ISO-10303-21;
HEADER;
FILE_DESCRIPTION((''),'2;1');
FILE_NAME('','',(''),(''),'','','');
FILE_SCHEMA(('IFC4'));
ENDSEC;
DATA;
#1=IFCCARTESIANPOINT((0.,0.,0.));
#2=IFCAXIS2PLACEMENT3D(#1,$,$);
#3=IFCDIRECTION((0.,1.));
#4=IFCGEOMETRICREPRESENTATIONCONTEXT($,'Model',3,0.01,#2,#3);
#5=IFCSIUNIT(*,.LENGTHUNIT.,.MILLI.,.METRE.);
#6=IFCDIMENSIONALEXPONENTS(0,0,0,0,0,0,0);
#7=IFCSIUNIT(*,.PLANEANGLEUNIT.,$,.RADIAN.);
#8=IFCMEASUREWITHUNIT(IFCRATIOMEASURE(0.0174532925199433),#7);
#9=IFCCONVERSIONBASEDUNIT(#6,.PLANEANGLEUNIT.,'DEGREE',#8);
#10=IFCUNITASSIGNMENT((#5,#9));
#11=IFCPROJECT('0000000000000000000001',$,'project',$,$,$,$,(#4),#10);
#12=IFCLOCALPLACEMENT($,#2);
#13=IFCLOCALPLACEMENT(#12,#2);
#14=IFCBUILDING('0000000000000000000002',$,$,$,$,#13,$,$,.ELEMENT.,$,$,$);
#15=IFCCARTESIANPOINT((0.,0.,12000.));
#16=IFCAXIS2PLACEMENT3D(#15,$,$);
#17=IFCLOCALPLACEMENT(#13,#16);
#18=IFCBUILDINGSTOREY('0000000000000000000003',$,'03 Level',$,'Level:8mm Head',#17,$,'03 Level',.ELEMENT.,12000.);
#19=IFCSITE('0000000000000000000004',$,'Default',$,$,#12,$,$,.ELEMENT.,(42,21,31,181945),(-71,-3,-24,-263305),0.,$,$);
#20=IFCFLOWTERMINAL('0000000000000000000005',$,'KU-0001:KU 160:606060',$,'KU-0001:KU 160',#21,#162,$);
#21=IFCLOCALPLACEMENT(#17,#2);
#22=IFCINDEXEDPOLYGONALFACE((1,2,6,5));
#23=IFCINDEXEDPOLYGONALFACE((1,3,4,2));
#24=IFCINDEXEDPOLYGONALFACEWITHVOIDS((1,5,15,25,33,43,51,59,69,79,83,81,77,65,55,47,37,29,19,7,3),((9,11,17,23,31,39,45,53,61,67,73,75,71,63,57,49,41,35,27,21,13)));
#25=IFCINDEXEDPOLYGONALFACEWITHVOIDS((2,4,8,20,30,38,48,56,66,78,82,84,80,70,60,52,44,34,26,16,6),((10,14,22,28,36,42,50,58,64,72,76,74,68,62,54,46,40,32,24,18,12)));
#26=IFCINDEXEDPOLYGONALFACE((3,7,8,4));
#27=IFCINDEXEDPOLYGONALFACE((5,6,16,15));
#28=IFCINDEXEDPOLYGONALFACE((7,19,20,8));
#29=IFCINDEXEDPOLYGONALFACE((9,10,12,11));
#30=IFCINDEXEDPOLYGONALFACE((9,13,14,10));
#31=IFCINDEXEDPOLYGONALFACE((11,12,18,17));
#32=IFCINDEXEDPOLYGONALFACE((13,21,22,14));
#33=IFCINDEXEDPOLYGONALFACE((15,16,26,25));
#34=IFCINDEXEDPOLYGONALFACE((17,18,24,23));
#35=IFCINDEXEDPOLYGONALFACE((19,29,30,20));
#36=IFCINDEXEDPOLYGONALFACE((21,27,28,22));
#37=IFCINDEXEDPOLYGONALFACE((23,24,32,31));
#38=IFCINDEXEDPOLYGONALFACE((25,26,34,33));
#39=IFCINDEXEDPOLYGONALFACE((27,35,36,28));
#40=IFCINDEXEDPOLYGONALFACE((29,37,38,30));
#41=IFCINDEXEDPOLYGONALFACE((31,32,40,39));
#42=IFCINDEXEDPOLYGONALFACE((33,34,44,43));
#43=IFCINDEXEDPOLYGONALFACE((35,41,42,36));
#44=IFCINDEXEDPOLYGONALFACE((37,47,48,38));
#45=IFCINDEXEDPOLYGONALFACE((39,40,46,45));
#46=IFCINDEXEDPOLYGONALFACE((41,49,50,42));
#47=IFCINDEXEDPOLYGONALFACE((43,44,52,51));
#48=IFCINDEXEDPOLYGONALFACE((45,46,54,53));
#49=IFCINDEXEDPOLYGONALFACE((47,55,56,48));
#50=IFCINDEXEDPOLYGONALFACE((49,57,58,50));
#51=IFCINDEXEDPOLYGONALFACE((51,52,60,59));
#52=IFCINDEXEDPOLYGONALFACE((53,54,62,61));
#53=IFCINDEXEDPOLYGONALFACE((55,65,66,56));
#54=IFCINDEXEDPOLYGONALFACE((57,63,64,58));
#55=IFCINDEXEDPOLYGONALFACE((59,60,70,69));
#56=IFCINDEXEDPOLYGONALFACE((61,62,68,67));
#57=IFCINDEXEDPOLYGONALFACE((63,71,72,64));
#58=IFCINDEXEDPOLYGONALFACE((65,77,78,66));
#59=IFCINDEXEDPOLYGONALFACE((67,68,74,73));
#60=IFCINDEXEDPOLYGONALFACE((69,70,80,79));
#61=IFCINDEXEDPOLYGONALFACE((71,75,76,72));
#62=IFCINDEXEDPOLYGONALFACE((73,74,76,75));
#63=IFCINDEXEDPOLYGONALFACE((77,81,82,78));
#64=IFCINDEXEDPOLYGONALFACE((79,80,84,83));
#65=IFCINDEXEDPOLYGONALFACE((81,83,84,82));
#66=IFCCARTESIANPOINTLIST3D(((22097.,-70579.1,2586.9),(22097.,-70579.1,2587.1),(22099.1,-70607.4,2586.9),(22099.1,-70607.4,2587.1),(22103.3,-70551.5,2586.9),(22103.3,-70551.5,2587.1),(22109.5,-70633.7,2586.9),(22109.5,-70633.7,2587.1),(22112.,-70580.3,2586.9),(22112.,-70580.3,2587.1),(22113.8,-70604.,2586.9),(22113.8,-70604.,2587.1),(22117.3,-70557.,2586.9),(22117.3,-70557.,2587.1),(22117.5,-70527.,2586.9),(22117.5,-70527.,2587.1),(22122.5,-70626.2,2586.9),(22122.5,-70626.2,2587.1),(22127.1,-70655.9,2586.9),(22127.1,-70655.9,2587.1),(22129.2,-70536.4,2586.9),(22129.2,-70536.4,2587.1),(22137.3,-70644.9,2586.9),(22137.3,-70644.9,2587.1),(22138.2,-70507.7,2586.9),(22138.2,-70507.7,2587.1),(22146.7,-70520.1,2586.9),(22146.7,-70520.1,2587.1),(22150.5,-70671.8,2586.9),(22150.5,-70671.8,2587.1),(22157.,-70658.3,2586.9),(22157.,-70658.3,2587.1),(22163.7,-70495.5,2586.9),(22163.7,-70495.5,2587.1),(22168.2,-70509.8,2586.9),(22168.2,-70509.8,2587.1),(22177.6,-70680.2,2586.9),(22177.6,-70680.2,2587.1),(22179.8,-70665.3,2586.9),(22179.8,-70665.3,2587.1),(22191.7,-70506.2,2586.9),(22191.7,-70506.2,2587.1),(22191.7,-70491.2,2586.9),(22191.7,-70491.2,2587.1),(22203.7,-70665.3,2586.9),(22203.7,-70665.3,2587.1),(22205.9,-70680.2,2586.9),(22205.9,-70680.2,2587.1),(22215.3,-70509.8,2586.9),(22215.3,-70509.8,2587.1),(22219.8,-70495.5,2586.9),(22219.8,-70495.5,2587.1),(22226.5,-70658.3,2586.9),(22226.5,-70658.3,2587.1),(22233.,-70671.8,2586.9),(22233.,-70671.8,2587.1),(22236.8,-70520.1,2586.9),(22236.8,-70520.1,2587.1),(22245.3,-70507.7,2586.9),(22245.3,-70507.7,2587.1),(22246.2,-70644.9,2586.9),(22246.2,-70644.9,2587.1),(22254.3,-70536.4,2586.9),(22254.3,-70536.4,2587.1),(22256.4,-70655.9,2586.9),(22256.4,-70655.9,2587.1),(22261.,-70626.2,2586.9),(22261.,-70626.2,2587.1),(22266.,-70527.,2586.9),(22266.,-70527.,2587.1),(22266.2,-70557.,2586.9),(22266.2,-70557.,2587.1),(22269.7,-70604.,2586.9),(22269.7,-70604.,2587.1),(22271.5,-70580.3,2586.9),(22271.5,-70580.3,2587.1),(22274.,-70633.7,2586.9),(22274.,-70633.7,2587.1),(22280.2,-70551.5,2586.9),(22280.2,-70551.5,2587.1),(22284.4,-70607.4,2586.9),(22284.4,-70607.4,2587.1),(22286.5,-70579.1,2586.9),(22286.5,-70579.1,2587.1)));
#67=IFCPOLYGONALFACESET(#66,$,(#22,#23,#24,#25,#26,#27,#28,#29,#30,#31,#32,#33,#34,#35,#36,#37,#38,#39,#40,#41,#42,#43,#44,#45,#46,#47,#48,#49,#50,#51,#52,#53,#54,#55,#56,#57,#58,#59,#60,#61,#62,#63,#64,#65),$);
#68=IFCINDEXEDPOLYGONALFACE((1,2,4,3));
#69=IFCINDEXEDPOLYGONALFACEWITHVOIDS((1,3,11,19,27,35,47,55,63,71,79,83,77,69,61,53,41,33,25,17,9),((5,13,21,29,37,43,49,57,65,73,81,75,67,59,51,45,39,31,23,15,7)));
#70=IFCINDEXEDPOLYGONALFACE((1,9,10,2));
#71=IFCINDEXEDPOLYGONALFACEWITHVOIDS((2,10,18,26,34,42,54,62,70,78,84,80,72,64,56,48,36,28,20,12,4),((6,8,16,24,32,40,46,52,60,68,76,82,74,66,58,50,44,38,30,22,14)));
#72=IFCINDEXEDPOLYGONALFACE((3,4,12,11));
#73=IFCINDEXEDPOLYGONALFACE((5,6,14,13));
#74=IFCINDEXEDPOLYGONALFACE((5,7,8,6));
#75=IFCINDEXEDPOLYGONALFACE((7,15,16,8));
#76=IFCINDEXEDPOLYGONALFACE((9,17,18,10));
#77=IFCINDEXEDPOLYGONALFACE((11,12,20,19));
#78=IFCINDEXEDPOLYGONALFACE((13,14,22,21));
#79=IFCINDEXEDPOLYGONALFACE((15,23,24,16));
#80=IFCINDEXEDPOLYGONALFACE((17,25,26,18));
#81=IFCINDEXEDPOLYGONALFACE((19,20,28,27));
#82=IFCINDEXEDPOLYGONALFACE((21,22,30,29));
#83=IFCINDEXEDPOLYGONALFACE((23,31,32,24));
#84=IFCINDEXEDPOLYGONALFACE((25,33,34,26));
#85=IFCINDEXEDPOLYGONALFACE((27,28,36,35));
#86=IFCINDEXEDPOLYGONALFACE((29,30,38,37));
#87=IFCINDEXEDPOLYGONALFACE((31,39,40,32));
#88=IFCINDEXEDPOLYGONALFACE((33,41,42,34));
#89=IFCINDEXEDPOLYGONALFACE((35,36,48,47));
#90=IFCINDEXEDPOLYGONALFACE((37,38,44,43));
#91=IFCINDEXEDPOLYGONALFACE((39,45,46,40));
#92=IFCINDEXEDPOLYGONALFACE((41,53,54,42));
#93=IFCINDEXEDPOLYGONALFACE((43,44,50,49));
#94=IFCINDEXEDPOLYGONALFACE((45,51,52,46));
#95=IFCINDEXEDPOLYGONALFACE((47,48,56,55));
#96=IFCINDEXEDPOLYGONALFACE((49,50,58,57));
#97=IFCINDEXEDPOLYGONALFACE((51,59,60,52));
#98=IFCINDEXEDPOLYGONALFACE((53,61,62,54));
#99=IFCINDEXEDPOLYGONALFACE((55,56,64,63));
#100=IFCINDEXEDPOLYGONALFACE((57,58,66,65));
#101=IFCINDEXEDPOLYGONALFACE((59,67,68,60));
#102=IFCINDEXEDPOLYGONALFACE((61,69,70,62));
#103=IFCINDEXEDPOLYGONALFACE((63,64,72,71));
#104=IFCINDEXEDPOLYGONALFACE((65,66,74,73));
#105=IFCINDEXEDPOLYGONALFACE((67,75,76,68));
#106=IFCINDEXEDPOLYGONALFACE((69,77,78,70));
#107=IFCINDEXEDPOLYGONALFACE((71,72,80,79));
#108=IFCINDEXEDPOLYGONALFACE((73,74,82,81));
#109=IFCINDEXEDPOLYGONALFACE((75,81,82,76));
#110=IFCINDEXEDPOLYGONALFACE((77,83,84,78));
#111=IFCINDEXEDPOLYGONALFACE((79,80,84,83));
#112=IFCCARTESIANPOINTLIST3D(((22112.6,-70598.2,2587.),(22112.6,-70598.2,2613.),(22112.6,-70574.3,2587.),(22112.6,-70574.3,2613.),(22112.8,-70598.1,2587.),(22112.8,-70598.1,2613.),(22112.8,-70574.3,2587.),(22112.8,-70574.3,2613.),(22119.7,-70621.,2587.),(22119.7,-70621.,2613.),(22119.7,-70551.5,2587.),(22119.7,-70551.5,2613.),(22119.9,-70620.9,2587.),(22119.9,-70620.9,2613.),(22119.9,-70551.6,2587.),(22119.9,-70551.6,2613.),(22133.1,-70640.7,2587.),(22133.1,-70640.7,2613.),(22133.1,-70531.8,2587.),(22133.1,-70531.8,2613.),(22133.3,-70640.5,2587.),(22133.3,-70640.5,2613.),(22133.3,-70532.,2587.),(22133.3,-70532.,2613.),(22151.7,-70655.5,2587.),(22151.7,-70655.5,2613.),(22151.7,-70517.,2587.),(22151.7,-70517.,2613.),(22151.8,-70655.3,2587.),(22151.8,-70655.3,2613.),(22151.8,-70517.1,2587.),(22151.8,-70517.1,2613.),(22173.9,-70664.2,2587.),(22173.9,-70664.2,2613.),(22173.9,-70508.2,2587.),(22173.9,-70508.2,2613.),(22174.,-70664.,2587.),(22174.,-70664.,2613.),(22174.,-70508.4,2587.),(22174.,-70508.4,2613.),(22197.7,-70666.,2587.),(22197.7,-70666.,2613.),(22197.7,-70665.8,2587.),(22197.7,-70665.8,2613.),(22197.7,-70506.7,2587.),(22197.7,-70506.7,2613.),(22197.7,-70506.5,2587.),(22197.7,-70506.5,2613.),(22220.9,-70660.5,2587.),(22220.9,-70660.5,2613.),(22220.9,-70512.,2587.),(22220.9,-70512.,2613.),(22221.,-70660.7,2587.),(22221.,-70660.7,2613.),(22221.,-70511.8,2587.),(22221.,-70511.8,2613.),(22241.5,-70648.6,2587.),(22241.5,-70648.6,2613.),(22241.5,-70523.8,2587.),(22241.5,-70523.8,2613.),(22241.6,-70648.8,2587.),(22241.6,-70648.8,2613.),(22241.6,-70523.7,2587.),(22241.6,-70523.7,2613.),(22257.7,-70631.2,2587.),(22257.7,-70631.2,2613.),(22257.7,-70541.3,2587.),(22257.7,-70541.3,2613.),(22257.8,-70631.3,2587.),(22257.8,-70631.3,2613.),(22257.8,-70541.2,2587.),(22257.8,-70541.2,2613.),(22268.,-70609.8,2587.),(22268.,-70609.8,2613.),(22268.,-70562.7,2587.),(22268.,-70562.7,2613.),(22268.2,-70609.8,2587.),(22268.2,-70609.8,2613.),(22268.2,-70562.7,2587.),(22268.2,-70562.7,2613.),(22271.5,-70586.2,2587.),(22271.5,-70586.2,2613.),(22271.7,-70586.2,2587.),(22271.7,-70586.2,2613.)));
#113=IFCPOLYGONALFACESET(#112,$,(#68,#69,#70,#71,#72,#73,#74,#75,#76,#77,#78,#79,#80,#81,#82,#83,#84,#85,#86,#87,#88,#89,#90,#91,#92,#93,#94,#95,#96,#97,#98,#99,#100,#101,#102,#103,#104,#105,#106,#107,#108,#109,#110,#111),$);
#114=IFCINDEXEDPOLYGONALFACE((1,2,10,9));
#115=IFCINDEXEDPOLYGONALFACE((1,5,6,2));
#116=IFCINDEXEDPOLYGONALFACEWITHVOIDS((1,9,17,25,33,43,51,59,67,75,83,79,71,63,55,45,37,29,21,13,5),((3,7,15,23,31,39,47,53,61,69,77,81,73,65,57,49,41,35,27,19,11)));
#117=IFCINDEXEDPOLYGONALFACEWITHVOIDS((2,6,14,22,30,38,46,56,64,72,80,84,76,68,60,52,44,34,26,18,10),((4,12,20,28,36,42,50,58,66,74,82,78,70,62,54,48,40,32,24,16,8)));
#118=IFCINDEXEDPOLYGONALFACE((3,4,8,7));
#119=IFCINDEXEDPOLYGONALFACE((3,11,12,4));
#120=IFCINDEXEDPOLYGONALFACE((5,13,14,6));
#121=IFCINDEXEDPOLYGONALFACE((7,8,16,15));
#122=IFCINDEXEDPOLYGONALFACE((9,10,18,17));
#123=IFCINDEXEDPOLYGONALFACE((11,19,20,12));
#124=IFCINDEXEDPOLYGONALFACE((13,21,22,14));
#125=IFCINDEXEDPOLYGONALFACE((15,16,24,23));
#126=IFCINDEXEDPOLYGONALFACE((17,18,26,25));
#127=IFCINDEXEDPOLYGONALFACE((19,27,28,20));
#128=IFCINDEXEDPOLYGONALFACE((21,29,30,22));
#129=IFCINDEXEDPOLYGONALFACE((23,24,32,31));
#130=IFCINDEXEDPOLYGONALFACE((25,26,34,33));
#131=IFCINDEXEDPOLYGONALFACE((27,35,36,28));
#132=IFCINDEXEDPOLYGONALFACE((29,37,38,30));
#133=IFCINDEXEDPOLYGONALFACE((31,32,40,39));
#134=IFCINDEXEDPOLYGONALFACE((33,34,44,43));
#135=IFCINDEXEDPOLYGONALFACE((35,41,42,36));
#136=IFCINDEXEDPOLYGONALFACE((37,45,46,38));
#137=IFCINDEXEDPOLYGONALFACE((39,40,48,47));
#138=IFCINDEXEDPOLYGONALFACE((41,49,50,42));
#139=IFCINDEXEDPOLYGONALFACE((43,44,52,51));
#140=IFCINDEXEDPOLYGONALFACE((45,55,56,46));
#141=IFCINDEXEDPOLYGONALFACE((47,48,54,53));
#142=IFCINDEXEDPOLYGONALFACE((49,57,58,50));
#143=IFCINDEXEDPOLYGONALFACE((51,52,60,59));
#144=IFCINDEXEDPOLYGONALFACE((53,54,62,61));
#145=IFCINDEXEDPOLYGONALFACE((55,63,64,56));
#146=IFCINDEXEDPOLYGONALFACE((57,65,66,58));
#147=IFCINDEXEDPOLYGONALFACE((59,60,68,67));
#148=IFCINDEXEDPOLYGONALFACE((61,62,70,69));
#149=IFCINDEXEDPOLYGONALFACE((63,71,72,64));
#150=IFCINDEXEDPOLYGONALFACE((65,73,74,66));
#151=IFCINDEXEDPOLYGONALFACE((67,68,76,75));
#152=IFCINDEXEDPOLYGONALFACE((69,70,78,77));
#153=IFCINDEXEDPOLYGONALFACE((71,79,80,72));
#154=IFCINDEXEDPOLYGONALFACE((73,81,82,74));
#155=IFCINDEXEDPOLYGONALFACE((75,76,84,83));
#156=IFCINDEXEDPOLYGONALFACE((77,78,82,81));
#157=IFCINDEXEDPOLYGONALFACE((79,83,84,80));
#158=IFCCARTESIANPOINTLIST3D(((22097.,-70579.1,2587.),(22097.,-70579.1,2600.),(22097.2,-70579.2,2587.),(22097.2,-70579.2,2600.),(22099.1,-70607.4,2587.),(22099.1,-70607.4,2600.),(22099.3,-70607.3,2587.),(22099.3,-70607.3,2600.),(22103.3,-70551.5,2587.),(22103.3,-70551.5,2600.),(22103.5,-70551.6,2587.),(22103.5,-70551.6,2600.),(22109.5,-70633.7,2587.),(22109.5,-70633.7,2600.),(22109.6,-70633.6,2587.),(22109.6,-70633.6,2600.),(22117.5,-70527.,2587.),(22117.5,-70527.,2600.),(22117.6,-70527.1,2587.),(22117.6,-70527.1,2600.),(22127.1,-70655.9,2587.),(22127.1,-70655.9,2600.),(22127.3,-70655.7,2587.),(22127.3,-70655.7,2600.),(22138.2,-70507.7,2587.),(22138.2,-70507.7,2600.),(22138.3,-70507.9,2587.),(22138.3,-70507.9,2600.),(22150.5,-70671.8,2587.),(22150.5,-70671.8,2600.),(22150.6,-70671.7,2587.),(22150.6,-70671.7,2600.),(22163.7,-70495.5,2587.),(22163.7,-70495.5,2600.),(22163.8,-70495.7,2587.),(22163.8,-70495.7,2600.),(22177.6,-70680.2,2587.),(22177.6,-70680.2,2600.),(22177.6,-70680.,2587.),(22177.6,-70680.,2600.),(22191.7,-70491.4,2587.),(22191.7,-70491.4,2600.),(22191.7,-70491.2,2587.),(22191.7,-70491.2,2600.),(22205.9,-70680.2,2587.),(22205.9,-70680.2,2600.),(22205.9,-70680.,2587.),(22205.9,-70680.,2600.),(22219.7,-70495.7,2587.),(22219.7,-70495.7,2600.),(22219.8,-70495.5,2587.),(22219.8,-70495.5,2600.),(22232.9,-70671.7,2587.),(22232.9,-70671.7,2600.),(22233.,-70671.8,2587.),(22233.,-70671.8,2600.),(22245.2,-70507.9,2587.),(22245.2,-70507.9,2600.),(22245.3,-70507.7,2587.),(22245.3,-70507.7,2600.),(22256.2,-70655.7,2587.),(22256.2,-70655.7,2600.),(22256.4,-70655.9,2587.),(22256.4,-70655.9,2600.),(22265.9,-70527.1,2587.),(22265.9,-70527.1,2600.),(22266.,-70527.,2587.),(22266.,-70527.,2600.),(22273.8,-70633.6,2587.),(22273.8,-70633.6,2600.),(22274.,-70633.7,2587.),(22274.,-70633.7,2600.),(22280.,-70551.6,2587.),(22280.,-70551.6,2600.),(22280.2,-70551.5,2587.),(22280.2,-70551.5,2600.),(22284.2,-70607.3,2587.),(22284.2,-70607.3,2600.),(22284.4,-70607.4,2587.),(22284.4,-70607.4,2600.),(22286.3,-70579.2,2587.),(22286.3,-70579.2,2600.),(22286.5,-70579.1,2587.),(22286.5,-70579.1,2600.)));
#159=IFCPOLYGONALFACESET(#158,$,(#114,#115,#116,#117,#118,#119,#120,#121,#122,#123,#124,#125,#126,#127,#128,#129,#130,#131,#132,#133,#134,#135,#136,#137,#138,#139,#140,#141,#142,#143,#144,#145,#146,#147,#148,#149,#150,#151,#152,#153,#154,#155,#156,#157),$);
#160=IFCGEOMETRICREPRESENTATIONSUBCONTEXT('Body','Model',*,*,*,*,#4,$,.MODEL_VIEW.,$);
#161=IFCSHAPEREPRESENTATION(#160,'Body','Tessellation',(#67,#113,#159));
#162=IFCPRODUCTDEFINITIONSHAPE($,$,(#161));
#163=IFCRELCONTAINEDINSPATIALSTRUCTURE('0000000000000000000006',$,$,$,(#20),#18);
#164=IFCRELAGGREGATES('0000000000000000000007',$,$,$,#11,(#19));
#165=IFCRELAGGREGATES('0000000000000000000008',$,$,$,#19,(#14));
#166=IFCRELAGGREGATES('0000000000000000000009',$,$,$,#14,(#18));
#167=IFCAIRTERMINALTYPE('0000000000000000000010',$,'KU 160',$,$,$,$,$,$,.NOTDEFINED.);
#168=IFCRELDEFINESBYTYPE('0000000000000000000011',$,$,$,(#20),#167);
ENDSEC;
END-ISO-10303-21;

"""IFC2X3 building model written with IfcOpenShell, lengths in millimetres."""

from ifc_helpers import new_model, entity, si_unit, converted_unit, direction, frame, frame_2d, origin, place, context, subcontext, project, spatial, hollow_circle, extrude, source, transform, mapped, type_object, type_shapes, element, save


model = new_model("IFC2X3")

# Units and contexts
model_context = context("Model", 3, precision=0.01, world=origin(), true_north=direction((0.0, 1.0)))
body_context = subcontext(model_context, "Body", "Model", "MODEL_VIEW")
ifc_project = project(units=[si_unit("LENGTHUNIT", "METRE", prefix="MILLI"), converted_unit("PLANEANGLEUNIT", "DEGREE", entity("IfcRatioMeasure", 0.0174532925199433), si_unit("PLANEANGLEUNIT", "RADIAN"), dimensions=[0, 0, 0, 0, 0, 0, 0])], contexts=[model_context])

# Site, building, storey
site_placement = place(None, origin())
site = spatial("IfcSite", under=ifc_project, at=site_placement, Name="Default", CompositionType="ELEMENT", RefLatitude=(42, 21, 31, 181945), RefLongitude=(-71, -3, -24, -263305), RefElevation=0.0)
building_placement = place(site_placement, origin())
building = spatial("IfcBuilding", under=site, at=building_placement, CompositionType="ELEMENT")
storey_placement = place(building_placement, frame((0.0, 0.0, 12000.0)))
storey = spatial("IfcBuildingStorey", under=building, at=storey_placement, Name="03 Level", ObjectType="Level:8mm Head", LongName="03 Level", CompositionType="ELEMENT", Elevation=12000.0)

# Flow terminal
air_terminal_type_1 = type_object("IfcAirTerminalType", Name="KU 160", PredefinedType="NOTDEFINED")
shared_shape_1 = source(origin(), body_context, "Body", "SweptSolid", [
    extrude(hollow_circle(Radius=95.0, WallThickness=15.0, at=frame_2d((0.0, 0.0), x_axis=(1.0, 0.0))), frame((12.9, 0.0, 0.0), z_axis=(1.0, 0.0, 0.0), x_axis=(0.0, 1.0, 0.0)), (0.0, 0.0, 1.0), 0.2),
    extrude(hollow_circle(Radius=80.0, WallThickness=0.2, at=frame_2d((0.0, 0.0), x_axis=(1.0, 0.0))), frame((-13.0, 0.0, 0.0), z_axis=(1.0, 0.0, 0.0), x_axis=(0.0, 0.0, 1.0)), (0.0, 0.0, 1.0), 26.0),
    extrude(hollow_circle(Radius=95.0, WallThickness=0.2, at=frame_2d((0.0, 0.0), x_axis=(1.0, 0.0))), frame((0.0, 0.0, 0.0), z_axis=(1.0, 0.0, 0.0), x_axis=(0.0, 1.0, 0.0)), (0.0, 0.0, 1.0), 13.0),
])
type_shapes(air_terminal_type_1, [shared_shape_1])
for number, where, z_axis, x_axis, name in (
    (1, (22191.7, -70586.2, 2600.0), (1.0, 0.0, 0.0), (0.0, 0.0, -1.0), "KU-0001:KU 160:606060"),
):
    element("IfcFlowTerminal", number, at=place(storey_placement, frame(where, z_axis=z_axis, x_axis=x_axis)), inside=storey, type_object=air_terminal_type_1, Name=name, ObjectType="KU-0001:KU 160", context=body_context, shape_type="MappedRepresentation", body=[
        mapped(shared_shape_1, transform((0.0, 0.0, 0.0), scale=1.0)),
    ])

save(model, "model.ifc")
